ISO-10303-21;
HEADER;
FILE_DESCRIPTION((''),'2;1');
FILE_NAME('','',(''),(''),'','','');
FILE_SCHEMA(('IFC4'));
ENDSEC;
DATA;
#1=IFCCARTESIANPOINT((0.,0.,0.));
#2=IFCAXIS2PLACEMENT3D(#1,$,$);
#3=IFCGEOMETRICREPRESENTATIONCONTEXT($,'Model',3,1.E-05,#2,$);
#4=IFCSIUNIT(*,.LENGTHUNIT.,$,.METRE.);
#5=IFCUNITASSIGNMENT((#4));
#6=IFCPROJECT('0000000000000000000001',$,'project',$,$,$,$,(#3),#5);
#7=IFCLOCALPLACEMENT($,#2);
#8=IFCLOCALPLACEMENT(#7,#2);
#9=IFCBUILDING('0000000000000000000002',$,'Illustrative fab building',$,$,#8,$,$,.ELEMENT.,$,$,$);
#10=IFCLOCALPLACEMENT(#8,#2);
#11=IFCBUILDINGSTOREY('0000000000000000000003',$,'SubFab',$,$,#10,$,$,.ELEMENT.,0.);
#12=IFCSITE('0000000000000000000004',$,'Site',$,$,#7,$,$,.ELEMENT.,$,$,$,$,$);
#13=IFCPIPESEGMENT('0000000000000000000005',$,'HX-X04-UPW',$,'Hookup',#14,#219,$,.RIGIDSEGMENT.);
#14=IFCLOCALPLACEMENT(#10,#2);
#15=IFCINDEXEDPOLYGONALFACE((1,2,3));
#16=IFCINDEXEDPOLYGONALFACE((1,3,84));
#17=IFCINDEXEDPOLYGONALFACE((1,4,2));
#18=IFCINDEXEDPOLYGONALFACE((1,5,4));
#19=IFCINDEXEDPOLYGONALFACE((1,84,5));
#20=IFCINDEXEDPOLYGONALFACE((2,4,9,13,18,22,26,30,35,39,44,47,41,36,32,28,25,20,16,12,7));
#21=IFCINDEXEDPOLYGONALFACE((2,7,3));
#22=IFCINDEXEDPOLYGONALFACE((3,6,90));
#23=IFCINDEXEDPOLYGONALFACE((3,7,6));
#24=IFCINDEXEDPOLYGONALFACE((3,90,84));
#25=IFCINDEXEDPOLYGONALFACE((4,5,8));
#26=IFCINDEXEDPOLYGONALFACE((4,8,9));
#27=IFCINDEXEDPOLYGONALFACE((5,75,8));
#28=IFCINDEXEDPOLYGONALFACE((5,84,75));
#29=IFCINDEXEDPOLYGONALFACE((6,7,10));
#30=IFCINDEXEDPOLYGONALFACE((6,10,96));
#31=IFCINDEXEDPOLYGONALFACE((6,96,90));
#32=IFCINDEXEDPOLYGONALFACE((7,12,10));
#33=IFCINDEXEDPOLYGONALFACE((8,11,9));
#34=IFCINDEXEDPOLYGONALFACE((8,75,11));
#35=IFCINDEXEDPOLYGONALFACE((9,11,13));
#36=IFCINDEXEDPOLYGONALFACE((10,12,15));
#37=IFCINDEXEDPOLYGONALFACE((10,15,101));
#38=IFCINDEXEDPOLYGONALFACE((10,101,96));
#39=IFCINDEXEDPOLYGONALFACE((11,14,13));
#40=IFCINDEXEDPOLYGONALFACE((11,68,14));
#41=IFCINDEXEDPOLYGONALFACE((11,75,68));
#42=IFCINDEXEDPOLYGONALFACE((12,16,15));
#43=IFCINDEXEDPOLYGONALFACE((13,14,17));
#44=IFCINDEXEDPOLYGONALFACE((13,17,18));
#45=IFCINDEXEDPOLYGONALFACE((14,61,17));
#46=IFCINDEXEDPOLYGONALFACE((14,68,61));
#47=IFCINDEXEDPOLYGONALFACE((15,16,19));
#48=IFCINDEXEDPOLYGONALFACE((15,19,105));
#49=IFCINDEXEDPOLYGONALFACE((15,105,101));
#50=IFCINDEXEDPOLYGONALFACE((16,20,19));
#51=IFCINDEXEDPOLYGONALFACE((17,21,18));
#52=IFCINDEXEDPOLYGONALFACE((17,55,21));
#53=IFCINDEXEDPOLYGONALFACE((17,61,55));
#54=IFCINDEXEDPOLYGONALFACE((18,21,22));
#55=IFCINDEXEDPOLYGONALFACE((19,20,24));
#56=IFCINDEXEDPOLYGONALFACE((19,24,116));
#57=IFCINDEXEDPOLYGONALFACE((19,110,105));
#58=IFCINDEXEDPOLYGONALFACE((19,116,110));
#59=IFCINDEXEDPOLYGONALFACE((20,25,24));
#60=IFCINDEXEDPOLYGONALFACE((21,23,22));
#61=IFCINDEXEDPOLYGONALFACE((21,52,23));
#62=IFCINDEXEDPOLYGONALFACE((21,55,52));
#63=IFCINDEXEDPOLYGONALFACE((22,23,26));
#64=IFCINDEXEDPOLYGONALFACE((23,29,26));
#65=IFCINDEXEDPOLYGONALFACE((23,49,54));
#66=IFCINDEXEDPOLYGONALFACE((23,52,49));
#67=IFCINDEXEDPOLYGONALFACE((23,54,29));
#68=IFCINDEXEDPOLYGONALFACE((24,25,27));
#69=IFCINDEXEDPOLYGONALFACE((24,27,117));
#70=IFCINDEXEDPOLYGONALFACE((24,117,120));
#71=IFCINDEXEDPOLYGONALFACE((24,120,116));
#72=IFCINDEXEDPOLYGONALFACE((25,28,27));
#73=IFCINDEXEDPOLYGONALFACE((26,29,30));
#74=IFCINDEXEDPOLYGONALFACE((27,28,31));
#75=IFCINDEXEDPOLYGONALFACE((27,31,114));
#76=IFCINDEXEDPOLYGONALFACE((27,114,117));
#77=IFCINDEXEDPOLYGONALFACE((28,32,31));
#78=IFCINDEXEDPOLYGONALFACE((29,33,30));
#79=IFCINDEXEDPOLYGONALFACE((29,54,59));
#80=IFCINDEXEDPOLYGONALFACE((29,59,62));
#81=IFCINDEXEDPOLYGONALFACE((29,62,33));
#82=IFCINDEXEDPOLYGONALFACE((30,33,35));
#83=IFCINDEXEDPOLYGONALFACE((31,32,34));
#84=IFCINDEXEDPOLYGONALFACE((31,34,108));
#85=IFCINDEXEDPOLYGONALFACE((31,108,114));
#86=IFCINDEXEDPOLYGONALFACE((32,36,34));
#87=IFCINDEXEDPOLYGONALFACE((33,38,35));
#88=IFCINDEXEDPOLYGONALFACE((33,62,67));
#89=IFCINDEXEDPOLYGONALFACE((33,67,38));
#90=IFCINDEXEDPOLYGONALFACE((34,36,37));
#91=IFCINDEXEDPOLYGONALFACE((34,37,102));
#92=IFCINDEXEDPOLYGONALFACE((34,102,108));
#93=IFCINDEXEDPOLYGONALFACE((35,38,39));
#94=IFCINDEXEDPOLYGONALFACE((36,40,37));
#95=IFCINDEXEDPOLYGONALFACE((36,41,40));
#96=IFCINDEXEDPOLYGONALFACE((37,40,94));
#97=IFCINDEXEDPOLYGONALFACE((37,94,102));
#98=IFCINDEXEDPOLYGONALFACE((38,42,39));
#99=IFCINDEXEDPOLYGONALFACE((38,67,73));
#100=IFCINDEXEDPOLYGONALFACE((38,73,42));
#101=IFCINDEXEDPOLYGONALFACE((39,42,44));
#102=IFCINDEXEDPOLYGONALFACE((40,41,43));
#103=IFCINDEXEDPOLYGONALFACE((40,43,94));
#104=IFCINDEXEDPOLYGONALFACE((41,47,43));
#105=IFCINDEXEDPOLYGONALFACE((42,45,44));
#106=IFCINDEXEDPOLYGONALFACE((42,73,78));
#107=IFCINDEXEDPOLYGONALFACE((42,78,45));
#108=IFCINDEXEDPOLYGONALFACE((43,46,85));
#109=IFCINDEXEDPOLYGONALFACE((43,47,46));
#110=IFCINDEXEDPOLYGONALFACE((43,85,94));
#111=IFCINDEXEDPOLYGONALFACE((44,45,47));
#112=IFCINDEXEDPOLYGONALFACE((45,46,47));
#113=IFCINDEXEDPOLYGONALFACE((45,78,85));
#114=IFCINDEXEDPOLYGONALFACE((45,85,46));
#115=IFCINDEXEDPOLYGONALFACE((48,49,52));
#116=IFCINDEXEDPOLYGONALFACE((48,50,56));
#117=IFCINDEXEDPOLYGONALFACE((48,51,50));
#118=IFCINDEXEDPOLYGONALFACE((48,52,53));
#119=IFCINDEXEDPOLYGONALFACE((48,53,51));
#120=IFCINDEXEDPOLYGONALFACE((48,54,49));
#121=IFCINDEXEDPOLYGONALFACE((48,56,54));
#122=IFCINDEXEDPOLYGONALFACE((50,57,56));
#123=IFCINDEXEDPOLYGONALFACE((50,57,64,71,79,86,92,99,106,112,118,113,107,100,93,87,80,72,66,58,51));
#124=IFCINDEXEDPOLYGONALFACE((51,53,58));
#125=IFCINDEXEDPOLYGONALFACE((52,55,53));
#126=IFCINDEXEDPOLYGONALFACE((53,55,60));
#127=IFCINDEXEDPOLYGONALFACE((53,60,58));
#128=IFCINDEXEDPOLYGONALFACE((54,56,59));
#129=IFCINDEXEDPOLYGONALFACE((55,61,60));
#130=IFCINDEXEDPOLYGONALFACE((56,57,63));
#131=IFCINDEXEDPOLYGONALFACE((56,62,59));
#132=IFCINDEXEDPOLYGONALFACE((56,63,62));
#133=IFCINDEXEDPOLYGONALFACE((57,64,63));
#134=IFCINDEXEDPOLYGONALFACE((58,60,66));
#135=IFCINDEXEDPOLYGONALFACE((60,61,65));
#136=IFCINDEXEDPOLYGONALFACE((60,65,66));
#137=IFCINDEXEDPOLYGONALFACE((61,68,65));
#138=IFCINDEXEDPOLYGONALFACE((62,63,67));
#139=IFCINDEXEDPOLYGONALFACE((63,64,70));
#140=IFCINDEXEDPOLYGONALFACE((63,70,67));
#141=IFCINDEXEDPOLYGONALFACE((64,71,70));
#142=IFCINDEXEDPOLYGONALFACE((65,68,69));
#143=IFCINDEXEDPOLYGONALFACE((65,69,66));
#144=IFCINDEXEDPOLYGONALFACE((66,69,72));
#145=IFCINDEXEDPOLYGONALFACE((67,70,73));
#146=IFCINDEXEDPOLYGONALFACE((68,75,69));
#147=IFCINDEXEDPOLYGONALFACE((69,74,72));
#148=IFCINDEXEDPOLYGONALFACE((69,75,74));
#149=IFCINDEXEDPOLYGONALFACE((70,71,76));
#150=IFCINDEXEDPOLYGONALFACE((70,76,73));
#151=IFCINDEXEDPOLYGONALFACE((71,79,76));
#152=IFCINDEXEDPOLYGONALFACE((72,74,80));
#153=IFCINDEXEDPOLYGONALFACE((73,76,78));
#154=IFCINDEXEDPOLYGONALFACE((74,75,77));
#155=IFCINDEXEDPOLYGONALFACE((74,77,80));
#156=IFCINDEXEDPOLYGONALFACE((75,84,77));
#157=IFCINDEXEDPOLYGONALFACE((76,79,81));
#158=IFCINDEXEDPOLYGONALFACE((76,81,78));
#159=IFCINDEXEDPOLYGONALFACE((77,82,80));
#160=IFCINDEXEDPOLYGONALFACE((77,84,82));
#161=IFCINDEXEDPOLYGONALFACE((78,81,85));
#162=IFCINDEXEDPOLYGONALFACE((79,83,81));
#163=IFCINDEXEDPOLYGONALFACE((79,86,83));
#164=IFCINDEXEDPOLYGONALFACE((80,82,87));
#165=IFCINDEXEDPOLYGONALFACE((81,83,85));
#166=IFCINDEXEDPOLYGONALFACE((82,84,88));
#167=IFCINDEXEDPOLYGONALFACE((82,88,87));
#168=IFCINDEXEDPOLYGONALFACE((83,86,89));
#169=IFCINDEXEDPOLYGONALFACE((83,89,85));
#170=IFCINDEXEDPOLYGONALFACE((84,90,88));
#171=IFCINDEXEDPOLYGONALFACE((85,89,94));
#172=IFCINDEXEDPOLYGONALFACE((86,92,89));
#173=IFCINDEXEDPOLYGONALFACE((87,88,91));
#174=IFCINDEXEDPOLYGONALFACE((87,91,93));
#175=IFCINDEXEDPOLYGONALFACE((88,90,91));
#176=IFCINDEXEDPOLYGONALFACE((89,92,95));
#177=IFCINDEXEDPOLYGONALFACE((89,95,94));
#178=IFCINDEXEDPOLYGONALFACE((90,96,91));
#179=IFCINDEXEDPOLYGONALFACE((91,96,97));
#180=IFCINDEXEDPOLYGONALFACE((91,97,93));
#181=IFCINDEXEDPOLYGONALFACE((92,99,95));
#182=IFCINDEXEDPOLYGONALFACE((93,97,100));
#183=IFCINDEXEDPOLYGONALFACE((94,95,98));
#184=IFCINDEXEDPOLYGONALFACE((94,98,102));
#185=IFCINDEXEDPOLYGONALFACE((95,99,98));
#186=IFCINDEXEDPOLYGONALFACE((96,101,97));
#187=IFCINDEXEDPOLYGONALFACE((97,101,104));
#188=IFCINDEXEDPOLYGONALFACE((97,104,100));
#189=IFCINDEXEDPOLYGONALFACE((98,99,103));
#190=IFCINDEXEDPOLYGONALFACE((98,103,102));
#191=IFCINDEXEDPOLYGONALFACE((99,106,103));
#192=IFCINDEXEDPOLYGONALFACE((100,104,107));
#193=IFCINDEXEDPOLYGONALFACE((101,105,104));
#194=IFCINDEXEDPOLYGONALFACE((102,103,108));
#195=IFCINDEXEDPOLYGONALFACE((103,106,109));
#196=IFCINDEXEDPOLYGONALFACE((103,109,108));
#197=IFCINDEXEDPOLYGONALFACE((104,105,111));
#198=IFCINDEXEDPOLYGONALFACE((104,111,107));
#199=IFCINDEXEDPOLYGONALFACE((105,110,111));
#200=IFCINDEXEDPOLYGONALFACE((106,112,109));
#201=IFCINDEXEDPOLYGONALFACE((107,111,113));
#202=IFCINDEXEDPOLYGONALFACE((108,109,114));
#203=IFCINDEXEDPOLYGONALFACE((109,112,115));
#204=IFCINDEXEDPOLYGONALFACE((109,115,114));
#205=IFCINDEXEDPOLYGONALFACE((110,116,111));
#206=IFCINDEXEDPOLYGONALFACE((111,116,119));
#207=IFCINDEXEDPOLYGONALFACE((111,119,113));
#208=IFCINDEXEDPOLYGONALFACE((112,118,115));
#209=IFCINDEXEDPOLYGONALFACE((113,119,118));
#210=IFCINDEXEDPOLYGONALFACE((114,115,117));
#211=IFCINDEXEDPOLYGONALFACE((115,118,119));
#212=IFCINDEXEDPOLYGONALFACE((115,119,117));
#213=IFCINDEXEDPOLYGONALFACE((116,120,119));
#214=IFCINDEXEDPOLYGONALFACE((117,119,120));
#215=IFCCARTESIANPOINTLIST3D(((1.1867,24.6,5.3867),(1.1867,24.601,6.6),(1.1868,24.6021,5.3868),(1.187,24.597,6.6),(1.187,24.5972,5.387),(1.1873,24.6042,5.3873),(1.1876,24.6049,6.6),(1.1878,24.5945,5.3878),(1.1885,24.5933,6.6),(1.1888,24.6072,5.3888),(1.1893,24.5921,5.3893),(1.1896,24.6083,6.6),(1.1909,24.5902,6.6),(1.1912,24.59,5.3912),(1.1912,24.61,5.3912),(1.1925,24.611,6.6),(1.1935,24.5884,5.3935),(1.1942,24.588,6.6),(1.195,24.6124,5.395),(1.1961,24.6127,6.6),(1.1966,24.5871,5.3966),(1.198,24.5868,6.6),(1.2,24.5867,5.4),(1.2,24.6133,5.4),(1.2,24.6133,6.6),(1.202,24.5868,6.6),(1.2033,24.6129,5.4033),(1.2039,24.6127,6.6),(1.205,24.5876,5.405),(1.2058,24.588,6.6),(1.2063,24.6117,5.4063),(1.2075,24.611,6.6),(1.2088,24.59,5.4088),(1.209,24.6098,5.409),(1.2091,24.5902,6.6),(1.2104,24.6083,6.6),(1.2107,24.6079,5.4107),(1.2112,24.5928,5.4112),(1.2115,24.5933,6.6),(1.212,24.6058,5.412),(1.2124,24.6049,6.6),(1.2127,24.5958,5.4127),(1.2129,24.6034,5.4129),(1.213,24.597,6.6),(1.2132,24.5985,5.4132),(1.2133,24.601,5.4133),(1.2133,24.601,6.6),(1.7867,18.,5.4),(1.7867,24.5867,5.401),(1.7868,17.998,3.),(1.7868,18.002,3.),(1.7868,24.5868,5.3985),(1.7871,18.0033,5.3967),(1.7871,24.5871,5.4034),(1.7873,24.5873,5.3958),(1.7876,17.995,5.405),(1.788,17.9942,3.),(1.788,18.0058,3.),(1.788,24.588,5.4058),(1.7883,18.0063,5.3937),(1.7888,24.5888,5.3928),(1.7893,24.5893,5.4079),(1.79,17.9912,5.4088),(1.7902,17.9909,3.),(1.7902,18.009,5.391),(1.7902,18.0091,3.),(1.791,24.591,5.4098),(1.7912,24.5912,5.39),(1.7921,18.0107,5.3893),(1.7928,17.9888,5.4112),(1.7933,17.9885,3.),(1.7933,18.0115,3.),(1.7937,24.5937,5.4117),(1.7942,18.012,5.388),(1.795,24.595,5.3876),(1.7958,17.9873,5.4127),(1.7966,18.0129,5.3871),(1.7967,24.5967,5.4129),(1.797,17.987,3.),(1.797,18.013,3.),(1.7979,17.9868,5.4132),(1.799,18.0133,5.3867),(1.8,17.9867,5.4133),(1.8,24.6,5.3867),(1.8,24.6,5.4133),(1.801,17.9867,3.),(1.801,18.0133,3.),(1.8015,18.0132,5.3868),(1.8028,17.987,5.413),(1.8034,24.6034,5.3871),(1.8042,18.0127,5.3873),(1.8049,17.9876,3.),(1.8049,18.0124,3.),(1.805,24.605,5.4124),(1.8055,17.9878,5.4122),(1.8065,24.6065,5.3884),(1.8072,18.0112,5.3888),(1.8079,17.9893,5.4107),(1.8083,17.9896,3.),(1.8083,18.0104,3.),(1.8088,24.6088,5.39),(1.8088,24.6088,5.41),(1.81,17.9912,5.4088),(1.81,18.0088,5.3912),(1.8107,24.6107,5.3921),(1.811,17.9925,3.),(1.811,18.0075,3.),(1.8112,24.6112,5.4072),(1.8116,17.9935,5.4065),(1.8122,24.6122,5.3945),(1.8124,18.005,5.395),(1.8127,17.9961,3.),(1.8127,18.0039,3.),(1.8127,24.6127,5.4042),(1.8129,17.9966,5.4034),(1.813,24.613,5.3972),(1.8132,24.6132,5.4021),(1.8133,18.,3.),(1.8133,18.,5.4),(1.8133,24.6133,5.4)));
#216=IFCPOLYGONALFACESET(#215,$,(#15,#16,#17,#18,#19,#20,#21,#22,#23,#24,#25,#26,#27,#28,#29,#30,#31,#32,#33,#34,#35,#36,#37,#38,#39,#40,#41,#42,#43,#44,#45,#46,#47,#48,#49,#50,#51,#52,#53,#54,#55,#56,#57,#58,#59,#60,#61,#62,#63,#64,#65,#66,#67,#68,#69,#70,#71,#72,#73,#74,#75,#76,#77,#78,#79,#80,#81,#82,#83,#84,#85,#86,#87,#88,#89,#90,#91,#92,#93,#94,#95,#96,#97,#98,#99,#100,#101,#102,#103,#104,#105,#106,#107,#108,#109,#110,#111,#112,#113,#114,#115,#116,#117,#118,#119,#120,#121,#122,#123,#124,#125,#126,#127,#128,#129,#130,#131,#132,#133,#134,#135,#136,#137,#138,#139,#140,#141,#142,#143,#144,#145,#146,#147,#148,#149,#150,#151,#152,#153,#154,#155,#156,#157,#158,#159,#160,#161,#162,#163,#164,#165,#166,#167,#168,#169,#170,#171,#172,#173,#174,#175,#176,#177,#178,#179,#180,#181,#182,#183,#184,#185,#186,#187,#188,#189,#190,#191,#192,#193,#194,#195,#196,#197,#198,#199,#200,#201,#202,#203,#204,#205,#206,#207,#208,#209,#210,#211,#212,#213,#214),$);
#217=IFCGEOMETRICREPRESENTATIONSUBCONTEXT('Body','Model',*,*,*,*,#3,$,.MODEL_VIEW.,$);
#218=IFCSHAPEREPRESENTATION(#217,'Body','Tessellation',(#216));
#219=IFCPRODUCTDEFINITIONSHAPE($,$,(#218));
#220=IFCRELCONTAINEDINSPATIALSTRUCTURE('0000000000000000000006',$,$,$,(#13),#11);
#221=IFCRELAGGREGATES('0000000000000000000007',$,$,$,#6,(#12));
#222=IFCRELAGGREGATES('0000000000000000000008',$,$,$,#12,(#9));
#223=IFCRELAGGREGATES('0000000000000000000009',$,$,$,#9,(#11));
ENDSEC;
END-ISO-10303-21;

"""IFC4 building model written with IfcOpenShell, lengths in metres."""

from ifc_helpers import new_model, entity, si_unit, origin, place, context, subcontext, project, spatial, element, save


model = new_model("IFC4")

# Units and contexts
model_context = context("Model", 3, precision=1e-05, world=origin())
body_context = subcontext(model_context, "Body", "Model", "MODEL_VIEW")
ifc_project = project(units=[si_unit("LENGTHUNIT", "METRE")], contexts=[model_context])

# Site, building, storey
site_placement = place(None, origin())
site = spatial("IfcSite", under=ifc_project, at=site_placement, Name="Site", CompositionType="ELEMENT")
building_placement = place(site_placement, origin())
building = spatial("IfcBuilding", under=site, at=building_placement, Name="Illustrative fab building", CompositionType="ELEMENT")
storey_placement = place(building_placement, origin())
storey = spatial("IfcBuildingStorey", under=building, at=storey_placement, Name="SubFab", CompositionType="ELEMENT", Elevation=0.0)

# Pipe segment
pipe_segment_1_placement = place(storey_placement, origin())
element("IfcPipeSegment", 1, at=pipe_segment_1_placement, inside=storey, Name="HX-X04-UPW", ObjectType="Hookup", PredefinedType="RIGIDSEGMENT", context=body_context, shape_type="AdvancedSweptSolid", body=[
    entity("IfcSweptDiskSolid", entity("IfcPolyline", [entity("IfcCartesianPoint", [1.8, 18.0, 3.0]), entity("IfcCartesianPoint", [1.8, 18.0, 5.4]), entity("IfcCartesianPoint", [1.8, 24.6, 5.4]), entity("IfcCartesianPoint", [1.2, 24.6, 5.4]), entity("IfcCartesianPoint", [1.2, 24.6, 6.6])]), 0.0133),
])

save(model, "model.ifc")
